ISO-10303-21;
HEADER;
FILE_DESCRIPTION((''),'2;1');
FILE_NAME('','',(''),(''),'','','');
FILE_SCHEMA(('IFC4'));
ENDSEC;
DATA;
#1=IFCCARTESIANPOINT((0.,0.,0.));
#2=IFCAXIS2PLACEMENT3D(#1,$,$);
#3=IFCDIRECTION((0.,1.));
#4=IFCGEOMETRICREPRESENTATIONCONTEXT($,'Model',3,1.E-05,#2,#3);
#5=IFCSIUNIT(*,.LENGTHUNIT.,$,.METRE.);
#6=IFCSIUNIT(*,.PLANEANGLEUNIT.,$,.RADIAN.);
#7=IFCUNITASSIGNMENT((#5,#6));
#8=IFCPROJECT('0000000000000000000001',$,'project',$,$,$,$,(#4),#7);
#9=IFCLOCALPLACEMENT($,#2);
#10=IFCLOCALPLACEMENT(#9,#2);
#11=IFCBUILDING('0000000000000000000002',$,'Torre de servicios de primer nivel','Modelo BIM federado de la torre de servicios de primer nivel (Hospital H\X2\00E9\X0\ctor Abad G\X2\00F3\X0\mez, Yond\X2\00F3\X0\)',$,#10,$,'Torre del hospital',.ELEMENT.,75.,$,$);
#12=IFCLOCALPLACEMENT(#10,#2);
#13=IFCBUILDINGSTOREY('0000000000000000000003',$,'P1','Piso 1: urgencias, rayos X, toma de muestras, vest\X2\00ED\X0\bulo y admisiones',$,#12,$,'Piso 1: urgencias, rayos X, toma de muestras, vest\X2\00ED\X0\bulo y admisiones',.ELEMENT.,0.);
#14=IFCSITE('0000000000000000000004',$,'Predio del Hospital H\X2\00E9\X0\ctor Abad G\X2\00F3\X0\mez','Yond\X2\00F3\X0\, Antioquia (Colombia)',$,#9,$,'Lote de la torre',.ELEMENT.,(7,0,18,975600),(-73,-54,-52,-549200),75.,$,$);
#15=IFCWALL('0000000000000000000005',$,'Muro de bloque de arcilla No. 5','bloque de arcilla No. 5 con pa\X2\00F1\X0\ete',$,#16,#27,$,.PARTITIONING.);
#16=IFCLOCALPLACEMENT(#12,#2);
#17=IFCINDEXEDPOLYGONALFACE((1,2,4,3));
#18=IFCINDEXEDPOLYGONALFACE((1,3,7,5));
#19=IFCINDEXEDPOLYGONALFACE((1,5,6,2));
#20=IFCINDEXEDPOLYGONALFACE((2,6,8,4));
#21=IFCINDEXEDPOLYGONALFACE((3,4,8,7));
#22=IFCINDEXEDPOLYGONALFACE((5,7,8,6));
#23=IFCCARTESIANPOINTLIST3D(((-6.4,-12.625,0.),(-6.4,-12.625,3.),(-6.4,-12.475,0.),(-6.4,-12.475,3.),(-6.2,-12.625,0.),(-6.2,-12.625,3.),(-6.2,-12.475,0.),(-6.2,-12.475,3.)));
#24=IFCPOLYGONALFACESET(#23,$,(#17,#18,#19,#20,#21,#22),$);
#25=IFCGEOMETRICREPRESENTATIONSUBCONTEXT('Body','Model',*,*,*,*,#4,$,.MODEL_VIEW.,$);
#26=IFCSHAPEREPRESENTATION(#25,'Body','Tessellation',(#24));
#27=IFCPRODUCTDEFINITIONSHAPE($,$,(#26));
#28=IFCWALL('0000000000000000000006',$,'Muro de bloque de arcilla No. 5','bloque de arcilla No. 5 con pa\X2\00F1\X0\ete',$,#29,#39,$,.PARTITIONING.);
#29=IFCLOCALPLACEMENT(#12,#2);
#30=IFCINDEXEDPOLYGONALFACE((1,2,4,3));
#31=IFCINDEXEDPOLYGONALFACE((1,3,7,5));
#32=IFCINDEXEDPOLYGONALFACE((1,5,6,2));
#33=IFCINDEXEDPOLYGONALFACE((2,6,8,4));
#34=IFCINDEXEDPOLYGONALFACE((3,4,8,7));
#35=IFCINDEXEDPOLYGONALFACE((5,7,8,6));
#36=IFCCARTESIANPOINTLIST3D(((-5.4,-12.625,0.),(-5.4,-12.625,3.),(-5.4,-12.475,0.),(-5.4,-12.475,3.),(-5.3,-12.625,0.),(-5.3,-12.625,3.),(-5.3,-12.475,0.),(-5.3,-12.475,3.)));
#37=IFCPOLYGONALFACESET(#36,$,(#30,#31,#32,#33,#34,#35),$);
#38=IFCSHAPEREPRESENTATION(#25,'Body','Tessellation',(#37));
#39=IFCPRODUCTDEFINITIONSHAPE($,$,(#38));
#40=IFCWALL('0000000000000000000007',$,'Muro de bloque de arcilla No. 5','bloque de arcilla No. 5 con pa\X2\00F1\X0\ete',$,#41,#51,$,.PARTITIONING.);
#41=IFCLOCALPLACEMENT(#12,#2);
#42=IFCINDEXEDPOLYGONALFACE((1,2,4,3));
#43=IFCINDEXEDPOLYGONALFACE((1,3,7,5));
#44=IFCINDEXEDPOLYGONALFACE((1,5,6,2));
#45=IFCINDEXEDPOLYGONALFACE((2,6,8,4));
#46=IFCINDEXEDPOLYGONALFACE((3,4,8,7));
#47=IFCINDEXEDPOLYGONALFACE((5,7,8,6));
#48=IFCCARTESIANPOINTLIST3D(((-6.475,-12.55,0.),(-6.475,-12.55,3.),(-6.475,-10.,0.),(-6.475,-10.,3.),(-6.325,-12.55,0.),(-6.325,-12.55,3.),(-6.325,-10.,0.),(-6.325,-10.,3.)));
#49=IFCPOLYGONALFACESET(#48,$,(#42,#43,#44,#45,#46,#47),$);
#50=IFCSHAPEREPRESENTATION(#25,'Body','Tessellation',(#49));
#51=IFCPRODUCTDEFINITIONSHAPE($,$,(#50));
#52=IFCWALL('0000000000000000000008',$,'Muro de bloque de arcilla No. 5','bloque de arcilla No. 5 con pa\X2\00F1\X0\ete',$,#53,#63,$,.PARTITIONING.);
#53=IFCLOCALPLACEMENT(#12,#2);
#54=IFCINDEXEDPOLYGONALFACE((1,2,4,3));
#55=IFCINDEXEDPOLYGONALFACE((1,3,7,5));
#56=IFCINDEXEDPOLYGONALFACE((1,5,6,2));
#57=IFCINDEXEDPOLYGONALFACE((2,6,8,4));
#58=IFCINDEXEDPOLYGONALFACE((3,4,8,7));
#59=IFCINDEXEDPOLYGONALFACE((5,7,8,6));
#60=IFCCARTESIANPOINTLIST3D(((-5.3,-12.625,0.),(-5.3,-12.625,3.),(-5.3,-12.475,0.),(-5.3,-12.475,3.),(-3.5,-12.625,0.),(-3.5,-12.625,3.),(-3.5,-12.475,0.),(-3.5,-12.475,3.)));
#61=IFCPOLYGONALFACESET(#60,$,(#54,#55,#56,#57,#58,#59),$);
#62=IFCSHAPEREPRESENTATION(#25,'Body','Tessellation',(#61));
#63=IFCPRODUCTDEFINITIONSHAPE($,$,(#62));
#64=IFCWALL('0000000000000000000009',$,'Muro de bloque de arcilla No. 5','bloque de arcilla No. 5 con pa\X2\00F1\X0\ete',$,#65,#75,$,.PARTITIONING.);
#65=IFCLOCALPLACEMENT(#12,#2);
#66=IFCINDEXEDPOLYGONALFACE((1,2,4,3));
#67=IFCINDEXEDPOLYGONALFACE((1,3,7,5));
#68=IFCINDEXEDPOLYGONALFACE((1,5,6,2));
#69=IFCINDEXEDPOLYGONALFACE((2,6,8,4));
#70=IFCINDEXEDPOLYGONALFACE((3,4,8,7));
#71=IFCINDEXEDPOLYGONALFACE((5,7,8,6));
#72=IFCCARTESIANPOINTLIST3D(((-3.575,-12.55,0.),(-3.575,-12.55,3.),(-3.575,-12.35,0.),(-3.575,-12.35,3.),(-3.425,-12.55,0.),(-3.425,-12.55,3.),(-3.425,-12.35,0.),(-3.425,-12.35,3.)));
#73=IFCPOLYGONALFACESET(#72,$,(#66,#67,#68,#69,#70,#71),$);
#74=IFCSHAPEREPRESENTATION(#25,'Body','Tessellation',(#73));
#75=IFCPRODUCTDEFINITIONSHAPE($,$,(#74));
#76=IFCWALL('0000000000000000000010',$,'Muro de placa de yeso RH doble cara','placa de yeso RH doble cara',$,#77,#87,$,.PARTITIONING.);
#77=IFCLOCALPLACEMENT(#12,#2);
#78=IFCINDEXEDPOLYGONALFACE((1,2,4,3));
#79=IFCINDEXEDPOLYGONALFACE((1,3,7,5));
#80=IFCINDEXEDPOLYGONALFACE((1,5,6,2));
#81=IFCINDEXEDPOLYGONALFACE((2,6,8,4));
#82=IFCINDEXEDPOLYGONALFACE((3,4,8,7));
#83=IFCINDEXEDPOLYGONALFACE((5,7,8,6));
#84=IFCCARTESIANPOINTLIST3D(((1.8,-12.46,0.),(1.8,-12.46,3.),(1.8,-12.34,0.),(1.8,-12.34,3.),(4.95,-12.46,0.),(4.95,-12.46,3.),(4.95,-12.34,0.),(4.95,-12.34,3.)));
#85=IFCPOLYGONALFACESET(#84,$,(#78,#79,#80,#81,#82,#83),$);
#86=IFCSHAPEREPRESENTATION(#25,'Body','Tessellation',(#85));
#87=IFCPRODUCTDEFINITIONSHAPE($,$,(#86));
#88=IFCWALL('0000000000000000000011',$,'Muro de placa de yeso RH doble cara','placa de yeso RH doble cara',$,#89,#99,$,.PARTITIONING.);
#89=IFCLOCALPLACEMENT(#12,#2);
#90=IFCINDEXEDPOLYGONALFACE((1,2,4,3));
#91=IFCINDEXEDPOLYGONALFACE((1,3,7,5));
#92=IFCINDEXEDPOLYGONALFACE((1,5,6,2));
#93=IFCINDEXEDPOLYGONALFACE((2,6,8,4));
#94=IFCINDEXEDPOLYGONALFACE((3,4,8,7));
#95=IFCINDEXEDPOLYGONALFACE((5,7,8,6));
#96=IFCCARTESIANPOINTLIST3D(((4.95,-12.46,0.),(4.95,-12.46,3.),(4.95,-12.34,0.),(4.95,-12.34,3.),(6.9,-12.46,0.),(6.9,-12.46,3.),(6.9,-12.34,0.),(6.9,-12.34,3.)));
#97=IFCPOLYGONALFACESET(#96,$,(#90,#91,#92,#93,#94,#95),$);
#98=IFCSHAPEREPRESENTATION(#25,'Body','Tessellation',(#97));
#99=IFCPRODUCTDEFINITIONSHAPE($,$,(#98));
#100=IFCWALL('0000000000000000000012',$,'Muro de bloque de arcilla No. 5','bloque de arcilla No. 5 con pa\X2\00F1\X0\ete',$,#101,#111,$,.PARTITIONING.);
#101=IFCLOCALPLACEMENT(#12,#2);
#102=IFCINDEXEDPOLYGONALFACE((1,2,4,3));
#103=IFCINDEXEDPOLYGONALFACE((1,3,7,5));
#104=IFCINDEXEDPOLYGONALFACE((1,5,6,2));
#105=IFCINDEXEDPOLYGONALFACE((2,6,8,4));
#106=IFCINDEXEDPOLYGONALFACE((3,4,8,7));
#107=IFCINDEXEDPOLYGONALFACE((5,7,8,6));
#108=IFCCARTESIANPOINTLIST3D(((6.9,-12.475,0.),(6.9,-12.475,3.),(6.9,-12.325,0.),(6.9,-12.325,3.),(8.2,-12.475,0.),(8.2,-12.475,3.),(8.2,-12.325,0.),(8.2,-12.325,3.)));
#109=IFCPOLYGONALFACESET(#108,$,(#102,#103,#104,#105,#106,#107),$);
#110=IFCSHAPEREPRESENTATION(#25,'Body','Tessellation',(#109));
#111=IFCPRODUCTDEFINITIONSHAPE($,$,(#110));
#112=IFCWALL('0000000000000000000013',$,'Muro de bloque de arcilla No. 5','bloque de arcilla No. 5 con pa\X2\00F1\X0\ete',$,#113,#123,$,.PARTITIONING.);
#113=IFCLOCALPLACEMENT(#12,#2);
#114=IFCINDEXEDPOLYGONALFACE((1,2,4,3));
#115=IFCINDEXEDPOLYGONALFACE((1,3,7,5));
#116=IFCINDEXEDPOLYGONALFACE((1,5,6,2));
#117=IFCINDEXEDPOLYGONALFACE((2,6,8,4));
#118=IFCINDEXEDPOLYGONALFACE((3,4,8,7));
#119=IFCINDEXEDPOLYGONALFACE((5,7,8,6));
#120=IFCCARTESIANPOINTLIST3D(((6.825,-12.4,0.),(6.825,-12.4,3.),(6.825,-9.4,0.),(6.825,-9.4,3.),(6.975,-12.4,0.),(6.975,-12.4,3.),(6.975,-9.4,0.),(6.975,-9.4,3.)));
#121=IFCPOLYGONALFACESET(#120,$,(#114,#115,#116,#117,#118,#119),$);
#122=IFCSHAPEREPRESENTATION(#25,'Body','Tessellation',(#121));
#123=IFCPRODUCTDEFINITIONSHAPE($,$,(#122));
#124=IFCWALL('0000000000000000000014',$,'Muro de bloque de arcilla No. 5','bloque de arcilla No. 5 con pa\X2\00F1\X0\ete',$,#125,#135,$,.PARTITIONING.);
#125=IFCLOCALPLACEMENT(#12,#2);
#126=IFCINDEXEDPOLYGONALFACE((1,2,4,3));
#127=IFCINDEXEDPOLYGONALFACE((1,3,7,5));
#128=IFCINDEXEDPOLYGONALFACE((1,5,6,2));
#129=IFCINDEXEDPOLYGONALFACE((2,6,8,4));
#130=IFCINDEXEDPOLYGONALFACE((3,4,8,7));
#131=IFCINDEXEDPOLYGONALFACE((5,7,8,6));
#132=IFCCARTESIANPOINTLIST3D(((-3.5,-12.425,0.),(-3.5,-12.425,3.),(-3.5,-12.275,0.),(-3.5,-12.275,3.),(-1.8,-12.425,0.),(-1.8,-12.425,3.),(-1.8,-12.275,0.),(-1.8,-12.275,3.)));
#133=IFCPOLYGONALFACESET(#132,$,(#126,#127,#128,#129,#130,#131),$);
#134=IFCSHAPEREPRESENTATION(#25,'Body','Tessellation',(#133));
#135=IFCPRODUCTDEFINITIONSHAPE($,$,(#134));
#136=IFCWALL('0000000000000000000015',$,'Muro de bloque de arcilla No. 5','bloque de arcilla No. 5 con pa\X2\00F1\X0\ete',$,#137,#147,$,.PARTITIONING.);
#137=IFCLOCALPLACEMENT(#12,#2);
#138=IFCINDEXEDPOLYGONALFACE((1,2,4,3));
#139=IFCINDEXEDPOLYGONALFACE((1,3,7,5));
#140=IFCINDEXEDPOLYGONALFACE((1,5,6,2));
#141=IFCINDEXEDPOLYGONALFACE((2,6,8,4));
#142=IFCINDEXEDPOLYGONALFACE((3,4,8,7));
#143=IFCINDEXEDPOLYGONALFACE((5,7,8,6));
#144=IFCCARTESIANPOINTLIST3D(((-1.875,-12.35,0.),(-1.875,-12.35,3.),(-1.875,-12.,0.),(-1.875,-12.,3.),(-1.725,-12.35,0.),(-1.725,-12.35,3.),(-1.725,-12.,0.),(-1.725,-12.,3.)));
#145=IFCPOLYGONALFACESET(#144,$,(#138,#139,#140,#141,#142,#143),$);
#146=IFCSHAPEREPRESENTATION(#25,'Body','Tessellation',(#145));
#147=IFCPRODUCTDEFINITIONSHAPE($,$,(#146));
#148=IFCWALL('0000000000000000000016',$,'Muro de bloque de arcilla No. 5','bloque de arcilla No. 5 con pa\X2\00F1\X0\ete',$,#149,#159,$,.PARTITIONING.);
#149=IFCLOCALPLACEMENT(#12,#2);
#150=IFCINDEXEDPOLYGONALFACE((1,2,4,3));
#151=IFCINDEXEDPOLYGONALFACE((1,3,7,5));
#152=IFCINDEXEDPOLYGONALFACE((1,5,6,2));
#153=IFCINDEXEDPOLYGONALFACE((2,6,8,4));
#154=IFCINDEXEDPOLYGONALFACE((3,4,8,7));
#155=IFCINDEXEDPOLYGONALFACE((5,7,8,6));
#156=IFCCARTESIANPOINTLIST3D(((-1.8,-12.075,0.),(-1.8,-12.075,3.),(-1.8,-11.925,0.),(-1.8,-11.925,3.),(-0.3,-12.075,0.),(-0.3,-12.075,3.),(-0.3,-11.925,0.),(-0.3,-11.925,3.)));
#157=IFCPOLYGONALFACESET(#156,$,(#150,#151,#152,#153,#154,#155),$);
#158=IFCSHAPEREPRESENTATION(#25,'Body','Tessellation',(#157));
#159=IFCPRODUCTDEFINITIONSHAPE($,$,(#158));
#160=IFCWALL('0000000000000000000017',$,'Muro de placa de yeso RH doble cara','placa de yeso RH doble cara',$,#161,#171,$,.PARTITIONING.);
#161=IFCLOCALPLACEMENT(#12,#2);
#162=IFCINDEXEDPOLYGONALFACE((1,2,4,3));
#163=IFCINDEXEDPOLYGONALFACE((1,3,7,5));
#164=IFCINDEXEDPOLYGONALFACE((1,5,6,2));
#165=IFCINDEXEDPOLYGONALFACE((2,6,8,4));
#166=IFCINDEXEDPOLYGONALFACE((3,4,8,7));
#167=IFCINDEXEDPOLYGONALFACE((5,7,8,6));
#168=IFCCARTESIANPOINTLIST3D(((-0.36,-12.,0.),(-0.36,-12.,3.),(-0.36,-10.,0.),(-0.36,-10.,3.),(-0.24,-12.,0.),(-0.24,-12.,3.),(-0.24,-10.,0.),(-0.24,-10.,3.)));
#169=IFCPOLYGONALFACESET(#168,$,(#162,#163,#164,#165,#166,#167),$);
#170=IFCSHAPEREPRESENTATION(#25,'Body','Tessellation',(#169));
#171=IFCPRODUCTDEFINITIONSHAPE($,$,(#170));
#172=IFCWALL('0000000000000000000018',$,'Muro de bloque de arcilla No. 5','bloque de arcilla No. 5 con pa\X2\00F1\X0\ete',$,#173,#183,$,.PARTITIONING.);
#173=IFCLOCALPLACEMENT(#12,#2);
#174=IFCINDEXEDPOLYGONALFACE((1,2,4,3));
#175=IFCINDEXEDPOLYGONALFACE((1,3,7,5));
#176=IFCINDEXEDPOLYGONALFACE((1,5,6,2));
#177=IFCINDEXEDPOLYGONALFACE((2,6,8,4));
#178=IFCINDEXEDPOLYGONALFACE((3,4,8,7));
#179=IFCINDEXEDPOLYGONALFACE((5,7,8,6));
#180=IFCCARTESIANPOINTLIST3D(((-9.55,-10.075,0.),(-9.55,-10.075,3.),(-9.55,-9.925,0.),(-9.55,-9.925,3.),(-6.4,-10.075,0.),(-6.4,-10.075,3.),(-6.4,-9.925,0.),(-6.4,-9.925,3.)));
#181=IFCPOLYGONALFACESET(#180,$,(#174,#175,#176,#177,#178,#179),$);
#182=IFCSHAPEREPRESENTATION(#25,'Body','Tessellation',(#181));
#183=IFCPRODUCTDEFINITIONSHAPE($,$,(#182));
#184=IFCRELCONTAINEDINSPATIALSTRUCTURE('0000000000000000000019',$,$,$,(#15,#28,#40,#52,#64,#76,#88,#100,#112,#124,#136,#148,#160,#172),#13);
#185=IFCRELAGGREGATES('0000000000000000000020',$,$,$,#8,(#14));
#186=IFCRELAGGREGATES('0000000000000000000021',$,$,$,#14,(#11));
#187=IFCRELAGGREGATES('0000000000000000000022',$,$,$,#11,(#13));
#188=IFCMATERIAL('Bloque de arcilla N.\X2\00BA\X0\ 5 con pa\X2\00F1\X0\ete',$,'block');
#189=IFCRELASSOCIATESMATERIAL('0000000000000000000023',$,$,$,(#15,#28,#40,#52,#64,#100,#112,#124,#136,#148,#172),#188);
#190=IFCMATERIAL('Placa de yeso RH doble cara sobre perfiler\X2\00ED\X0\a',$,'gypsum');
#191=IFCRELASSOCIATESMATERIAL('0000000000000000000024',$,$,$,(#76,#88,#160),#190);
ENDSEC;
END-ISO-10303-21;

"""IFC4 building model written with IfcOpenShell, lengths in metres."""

from ifc_helpers import new_model, si_unit, direction, frame, origin, place, context, subcontext, project, spatial, rectangle, extrude, material, element, save


model = new_model("IFC4")

# Units and contexts
model_context = context("Model", 3, precision=1e-05, world=origin(), true_north=direction((0.0, 1.0)))
body_context = subcontext(model_context, "Body", "Model", "MODEL_VIEW")
ifc_project = project(units=[si_unit("LENGTHUNIT", "METRE"), si_unit("PLANEANGLEUNIT", "RADIAN")], contexts=[model_context])

# Site, building, storey
site_placement = place(None, origin())
site = spatial("IfcSite", under=ifc_project, at=site_placement, Name="Predio del Hospital Héctor Abad Gómez", Description="Yondó, Antioquia (Colombia)", LongName="Lote de la torre", CompositionType="ELEMENT", RefLatitude=(7, 0, 18, 975600), RefLongitude=(-73, -54, -52, -549200), RefElevation=75.0)
building_placement = place(site_placement, origin())
building = spatial("IfcBuilding", under=site, at=building_placement, Name="Torre de servicios de primer nivel", Description="Modelo BIM federado de la torre de servicios de primer nivel (Hospital Héctor Abad Gómez, Yondó)", LongName="Torre del hospital", CompositionType="ELEMENT", ElevationOfRefHeight=75.0)
placement = place(building_placement, origin())
storey = spatial("IfcBuildingStorey", under=building, at=placement, Name="P1", Description="Piso 1: urgencias, rayos X, toma de muestras, vestíbulo y admisiones", LongName="Piso 1: urgencias, rayos X, toma de muestras, vestíbulo y admisiones", CompositionType="ELEMENT", Elevation=0.0)

# Walls
ifc_material_1 = material(Name="Bloque de arcilla N.º 5 con pañete", Category="block")
element("IfcWall", 1, at=placement, inside=storey, material=ifc_material_1, Name="Muro de bloque de arcilla No. 5", Description="bloque de arcilla No. 5 con pañete", PredefinedType="PARTITIONING", context=body_context, shape_type="SweptSolid", body=[
    extrude(rectangle(XDim=0.2, YDim=0.15), frame((-6.3, -12.55, 0.0)), (0.0, 0.0, 1.0), 3.0),
])
element("IfcWall", 2, at=placement, inside=storey, material=ifc_material_1, Name="Muro de bloque de arcilla No. 5", Description="bloque de arcilla No. 5 con pañete", PredefinedType="PARTITIONING", context=body_context, shape_type="SweptSolid", body=[
    extrude(rectangle(XDim=0.1, YDim=0.15), frame((-5.35, -12.55, 0.0)), (0.0, 0.0, 1.0), 3.0),
])
element("IfcWall", 3, at=placement, inside=storey, material=ifc_material_1, Name="Muro de bloque de arcilla No. 5", Description="bloque de arcilla No. 5 con pañete", PredefinedType="PARTITIONING", context=body_context, shape_type="SweptSolid", body=[
    extrude(rectangle(XDim=0.15, YDim=2.55), frame((-6.4, -11.275, 0.0)), (0.0, 0.0, 1.0), 3.0),
])
element("IfcWall", 4, at=placement, inside=storey, material=ifc_material_1, Name="Muro de bloque de arcilla No. 5", Description="bloque de arcilla No. 5 con pañete", PredefinedType="PARTITIONING", context=body_context, shape_type="SweptSolid", body=[
    extrude(rectangle(XDim=1.8, YDim=0.15), frame((-4.4, -12.55, 0.0)), (0.0, 0.0, 1.0), 3.0),
])
element("IfcWall", 5, at=placement, inside=storey, material=ifc_material_1, Name="Muro de bloque de arcilla No. 5", Description="bloque de arcilla No. 5 con pañete", PredefinedType="PARTITIONING", context=body_context, shape_type="SweptSolid", body=[
    extrude(rectangle(XDim=0.15, YDim=0.2), frame((-3.5, -12.45, 0.0)), (0.0, 0.0, 1.0), 3.0),
])
ifc_material_2 = material(Name="Placa de yeso RH doble cara sobre perfilería", Category="gypsum")
element("IfcWall", 6, at=placement, inside=storey, material=ifc_material_2, Name="Muro de placa de yeso RH doble cara", Description="placa de yeso RH doble cara", PredefinedType="PARTITIONING", context=body_context, shape_type="SweptSolid", body=[
    extrude(rectangle(XDim=3.15, YDim=0.12), frame((3.375, -12.4, 0.0)), (0.0, 0.0, 1.0), 3.0),
])
element("IfcWall", 7, at=placement, inside=storey, material=ifc_material_2, Name="Muro de placa de yeso RH doble cara", Description="placa de yeso RH doble cara", PredefinedType="PARTITIONING", context=body_context, shape_type="SweptSolid", body=[
    extrude(rectangle(XDim=1.95, YDim=0.12), frame((5.925, -12.4, 0.0)), (0.0, 0.0, 1.0), 3.0),
])
element("IfcWall", 8, at=placement, inside=storey, material=ifc_material_1, Name="Muro de bloque de arcilla No. 5", Description="bloque de arcilla No. 5 con pañete", PredefinedType="PARTITIONING", context=body_context, shape_type="SweptSolid", body=[
    extrude(rectangle(XDim=1.3, YDim=0.15), frame((7.55, -12.4, 0.0)), (0.0, 0.0, 1.0), 3.0),
])
element("IfcWall", 9, at=placement, inside=storey, material=ifc_material_1, Name="Muro de bloque de arcilla No. 5", Description="bloque de arcilla No. 5 con pañete", PredefinedType="PARTITIONING", context=body_context, shape_type="SweptSolid", body=[
    extrude(rectangle(XDim=0.15, YDim=3.0), frame((6.9, -10.9, 0.0)), (0.0, 0.0, 1.0), 3.0),
])
element("IfcWall", 10, at=placement, inside=storey, material=ifc_material_1, Name="Muro de bloque de arcilla No. 5", Description="bloque de arcilla No. 5 con pañete", PredefinedType="PARTITIONING", context=body_context, shape_type="SweptSolid", body=[
    extrude(rectangle(XDim=1.7, YDim=0.15), frame((-2.65, -12.35, 0.0)), (0.0, 0.0, 1.0), 3.0),
])
element("IfcWall", 11, at=placement, inside=storey, material=ifc_material_1, Name="Muro de bloque de arcilla No. 5", Description="bloque de arcilla No. 5 con pañete", PredefinedType="PARTITIONING", context=body_context, shape_type="SweptSolid", body=[
    extrude(rectangle(XDim=0.15, YDim=0.35), frame((-1.8, -12.175, 0.0)), (0.0, 0.0, 1.0), 3.0),
])
element("IfcWall", 12, at=placement, inside=storey, material=ifc_material_1, Name="Muro de bloque de arcilla No. 5", Description="bloque de arcilla No. 5 con pañete", PredefinedType="PARTITIONING", context=body_context, shape_type="SweptSolid", body=[
    extrude(rectangle(XDim=1.5, YDim=0.15), frame((-1.05, -12.0, 0.0)), (0.0, 0.0, 1.0), 3.0),
])
element("IfcWall", 13, at=placement, inside=storey, material=ifc_material_2, Name="Muro de placa de yeso RH doble cara", Description="placa de yeso RH doble cara", PredefinedType="PARTITIONING", context=body_context, shape_type="SweptSolid", body=[
    extrude(rectangle(XDim=0.12, YDim=2.0), frame((-0.3, -11.0, 0.0)), (0.0, 0.0, 1.0), 3.0),
])
element("IfcWall", 14, at=placement, inside=storey, material=ifc_material_1, Name="Muro de bloque de arcilla No. 5", Description="bloque de arcilla No. 5 con pañete", PredefinedType="PARTITIONING", context=body_context, shape_type="SweptSolid", body=[
    extrude(rectangle(XDim=3.15, YDim=0.15), frame((-7.975, -10.0, 0.0)), (0.0, 0.0, 1.0), 3.0),
])

save(model, "model.ifc")
